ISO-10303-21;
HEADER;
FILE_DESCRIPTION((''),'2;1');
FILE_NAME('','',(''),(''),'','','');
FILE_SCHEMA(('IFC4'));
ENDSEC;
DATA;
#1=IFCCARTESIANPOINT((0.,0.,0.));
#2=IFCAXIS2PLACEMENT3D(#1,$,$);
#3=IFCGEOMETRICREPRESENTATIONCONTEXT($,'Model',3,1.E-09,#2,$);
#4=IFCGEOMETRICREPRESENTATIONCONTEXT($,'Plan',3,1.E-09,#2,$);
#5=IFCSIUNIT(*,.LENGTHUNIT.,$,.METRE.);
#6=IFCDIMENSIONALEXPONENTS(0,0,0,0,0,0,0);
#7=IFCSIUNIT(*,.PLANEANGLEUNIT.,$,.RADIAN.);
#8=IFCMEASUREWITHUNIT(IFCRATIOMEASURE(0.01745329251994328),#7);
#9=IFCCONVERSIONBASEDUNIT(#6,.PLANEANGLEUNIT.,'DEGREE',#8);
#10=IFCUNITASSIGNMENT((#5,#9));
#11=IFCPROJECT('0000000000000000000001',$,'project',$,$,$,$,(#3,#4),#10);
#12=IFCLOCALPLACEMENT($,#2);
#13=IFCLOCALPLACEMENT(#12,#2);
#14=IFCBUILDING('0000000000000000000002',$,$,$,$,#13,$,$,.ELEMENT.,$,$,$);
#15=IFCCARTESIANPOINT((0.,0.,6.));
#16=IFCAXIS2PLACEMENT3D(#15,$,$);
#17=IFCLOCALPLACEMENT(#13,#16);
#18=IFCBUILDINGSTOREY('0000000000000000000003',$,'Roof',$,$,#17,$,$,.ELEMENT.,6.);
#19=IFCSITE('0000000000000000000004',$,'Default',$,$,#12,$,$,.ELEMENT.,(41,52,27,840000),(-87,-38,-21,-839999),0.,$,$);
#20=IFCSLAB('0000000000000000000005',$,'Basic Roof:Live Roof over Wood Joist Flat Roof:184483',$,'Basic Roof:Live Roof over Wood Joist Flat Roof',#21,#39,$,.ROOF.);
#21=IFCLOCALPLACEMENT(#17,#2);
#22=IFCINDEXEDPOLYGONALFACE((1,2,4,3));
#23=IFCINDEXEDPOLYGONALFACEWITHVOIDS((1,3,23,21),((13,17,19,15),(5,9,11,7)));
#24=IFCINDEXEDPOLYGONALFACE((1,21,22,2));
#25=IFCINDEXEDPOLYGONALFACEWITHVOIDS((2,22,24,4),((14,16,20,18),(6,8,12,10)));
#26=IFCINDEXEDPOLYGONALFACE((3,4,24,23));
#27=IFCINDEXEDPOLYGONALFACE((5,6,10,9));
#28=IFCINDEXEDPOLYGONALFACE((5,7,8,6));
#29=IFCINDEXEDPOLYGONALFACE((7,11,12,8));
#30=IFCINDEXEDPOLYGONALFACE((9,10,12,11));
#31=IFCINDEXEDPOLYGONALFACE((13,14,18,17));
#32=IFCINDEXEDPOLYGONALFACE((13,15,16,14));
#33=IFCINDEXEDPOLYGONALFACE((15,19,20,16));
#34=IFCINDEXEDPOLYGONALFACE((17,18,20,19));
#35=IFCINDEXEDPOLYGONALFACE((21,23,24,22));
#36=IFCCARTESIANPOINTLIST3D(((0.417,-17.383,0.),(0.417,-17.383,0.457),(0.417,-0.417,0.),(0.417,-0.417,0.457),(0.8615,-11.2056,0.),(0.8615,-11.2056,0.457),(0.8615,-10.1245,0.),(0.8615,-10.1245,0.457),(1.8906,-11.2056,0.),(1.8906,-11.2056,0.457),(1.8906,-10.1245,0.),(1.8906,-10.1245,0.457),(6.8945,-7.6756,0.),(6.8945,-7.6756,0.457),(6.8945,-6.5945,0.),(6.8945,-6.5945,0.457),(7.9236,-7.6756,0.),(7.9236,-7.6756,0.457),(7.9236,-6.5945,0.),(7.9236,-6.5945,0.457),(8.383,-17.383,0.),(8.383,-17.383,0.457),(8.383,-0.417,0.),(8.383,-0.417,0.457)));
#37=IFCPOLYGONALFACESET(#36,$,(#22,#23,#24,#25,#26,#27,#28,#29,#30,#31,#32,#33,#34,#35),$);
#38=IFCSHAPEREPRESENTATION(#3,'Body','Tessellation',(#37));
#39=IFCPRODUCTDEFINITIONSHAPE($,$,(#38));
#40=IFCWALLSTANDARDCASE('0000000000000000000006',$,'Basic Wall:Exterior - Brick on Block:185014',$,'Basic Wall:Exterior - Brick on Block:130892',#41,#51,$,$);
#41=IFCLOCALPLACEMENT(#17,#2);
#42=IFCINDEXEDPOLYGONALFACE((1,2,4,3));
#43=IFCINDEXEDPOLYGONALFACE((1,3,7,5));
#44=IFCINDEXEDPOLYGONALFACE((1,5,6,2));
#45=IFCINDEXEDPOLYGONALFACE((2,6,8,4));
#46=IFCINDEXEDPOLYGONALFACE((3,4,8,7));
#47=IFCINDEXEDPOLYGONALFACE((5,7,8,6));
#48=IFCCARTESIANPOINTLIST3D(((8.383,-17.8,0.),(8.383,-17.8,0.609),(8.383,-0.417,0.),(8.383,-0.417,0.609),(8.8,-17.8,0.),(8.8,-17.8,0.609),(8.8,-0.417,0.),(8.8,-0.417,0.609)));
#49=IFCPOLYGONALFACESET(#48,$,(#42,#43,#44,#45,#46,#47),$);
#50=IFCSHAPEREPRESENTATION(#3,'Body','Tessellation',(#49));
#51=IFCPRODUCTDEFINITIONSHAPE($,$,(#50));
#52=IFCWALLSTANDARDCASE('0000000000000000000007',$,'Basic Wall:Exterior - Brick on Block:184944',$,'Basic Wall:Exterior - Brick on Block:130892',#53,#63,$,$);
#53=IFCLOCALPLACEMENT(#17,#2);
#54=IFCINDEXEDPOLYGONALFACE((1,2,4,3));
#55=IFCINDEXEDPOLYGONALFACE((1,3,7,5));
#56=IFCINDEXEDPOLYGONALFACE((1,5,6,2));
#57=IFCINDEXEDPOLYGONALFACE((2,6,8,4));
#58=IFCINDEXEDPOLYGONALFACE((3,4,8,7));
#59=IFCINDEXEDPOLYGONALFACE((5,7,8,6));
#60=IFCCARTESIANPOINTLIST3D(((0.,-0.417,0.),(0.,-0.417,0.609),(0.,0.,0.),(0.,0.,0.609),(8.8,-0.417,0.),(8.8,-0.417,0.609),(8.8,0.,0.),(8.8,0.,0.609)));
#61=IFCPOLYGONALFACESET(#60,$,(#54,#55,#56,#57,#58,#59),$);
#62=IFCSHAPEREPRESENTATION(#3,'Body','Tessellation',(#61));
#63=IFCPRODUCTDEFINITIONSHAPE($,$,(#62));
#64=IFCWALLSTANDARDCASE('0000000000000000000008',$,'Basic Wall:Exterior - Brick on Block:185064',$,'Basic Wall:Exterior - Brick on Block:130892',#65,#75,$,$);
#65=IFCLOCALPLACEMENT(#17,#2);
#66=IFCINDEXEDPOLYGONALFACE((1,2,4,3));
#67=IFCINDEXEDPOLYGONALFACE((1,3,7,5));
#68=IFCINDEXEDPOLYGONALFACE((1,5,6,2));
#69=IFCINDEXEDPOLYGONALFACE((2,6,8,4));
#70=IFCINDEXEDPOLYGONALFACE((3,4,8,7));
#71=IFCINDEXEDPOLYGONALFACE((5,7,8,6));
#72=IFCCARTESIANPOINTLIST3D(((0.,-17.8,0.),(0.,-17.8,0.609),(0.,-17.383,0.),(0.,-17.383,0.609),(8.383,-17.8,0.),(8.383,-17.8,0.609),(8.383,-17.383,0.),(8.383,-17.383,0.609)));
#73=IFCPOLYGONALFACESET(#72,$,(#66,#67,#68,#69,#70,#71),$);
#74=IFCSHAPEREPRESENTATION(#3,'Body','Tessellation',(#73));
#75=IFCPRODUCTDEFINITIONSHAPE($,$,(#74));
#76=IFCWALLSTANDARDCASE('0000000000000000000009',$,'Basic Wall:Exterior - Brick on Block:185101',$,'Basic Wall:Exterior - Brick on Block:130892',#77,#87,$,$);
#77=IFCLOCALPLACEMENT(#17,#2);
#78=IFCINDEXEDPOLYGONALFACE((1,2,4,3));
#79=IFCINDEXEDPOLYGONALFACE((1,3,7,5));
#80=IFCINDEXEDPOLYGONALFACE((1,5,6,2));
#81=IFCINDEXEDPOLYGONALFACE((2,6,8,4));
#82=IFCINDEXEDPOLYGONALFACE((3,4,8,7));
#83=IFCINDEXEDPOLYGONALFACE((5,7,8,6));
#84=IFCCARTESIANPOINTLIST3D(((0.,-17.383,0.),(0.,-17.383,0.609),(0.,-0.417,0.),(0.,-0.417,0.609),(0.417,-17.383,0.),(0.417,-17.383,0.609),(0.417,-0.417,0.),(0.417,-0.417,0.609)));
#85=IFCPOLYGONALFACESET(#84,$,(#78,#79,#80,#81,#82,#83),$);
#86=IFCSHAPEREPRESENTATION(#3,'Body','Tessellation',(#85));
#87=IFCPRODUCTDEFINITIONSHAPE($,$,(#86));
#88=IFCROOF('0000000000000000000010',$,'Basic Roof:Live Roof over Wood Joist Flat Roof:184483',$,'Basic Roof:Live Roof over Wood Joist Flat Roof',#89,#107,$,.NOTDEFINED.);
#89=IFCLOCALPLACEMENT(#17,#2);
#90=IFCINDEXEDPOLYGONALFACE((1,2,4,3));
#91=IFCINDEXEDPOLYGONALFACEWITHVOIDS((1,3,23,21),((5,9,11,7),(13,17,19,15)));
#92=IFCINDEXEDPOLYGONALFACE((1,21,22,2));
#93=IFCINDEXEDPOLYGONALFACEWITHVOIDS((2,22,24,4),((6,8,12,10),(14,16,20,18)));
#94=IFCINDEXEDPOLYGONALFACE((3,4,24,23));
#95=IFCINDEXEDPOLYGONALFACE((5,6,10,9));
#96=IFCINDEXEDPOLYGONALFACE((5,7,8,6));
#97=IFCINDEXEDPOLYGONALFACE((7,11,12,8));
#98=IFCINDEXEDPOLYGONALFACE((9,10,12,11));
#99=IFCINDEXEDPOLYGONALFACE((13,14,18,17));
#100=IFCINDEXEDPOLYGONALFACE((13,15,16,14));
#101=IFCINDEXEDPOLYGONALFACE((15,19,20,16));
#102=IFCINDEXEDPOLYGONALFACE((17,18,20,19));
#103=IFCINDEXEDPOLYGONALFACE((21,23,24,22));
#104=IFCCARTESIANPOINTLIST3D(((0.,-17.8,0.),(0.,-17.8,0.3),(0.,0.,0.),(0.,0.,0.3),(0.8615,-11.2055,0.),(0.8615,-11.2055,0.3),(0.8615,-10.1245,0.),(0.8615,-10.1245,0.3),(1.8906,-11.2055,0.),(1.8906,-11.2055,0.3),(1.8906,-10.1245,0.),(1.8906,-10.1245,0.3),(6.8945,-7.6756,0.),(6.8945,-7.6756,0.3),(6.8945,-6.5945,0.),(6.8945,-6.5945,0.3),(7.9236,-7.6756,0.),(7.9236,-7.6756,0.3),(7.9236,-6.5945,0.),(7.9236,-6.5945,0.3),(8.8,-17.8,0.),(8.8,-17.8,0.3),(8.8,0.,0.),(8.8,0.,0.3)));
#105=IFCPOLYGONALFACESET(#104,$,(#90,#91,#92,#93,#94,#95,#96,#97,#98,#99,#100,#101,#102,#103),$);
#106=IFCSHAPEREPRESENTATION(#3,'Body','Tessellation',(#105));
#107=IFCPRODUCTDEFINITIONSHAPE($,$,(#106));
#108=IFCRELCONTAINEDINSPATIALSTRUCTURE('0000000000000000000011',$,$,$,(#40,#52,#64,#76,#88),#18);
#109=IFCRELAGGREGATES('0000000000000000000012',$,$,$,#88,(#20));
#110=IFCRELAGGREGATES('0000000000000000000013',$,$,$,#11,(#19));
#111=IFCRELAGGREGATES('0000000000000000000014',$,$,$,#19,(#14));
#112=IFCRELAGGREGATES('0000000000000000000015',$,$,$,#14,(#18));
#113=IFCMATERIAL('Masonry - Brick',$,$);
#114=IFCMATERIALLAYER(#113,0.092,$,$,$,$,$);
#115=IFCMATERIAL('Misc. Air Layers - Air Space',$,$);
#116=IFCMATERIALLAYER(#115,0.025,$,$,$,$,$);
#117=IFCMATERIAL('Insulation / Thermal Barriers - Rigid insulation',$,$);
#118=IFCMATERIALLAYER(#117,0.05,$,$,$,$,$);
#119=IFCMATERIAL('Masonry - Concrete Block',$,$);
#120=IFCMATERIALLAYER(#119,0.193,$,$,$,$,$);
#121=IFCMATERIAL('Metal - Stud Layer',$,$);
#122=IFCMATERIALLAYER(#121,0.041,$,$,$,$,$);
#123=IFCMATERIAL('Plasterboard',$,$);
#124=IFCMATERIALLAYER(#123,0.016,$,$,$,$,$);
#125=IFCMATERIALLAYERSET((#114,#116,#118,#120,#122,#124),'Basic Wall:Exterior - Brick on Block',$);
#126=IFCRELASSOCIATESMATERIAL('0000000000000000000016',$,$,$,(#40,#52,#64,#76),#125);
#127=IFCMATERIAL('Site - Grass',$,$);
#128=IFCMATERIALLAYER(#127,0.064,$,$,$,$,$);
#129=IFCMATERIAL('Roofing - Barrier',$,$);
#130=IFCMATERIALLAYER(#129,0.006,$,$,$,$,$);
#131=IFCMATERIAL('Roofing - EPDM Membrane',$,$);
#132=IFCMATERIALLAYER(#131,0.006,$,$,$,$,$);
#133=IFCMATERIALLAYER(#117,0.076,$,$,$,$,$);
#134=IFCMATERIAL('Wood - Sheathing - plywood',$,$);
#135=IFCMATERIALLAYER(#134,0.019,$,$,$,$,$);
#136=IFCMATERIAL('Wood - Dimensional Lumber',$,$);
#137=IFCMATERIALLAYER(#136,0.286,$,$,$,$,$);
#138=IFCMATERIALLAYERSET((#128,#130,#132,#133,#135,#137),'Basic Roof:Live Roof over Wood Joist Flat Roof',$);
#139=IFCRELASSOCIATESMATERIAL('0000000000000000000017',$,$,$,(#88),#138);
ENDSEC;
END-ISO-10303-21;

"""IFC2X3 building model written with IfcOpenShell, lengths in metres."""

from ifc_helpers import new_model, entity, si_unit, converted_unit, frame, frame_2d, origin, origin_2d_with_axis, place, context, project, spatial, polyline, rectangle, outline, extrude, material, layer, layer_set, layer_usage, element, aggregate, save


model = new_model("IFC2X3")

# Units and contexts
model_context = context("Model", 3, precision=1e-09, world=origin())
plan_context = context("Plan", 3, precision=1e-09, world=origin())
ifc_project = project(units=[si_unit("LENGTHUNIT", "METRE"), converted_unit("PLANEANGLEUNIT", "DEGREE", entity("IfcRatioMeasure", 0.01745329251994328), si_unit("PLANEANGLEUNIT", "RADIAN"), dimensions=[0, 0, 0, 0, 0, 0, 0])], contexts=[model_context, plan_context])

# Slab, openings
site_placement = place(None, origin())
building_placement = place(site_placement, origin())
storey_placement = place(building_placement, frame((0.0, 0.0, 6.0)))
roof_placement = place(storey_placement, origin())
slab_placement = place(roof_placement, frame((0.417, -17.383, 0.0)))
slab = element("IfcSlab", 1, at=slab_placement, Name="Basic Roof:Live Roof over Wood Joist Flat Roof:184483", ObjectType="Basic Roof:Live Roof over Wood Joist Flat Roof", PredefinedType="ROOF", context=model_context, shape_type="SweptSolid", body=[
    extrude(rectangle(XDim=7.966, YDim=16.966, at=origin_2d_with_axis()), frame((3.983, 8.483, 0.0)), (0.0, 0.0, 1.0), 0.457),
])
opening_1_placement = place(roof_placement, frame((1.376, -10.665, 0.0)))
element("IfcOpeningElement", 2, at=opening_1_placement, cuts=slab, ObjectType="Opening", context=model_context, shape_type="SweptSolid", body=[
    extrude(rectangle(XDim=1.0291, YDim=1.0811, at=origin_2d_with_axis()), frame((0.0, 0.0, 0.0), z_axis=(0.0, 0.0, 1.0), x_axis=(-1.0, 0.0, 0.0)), (0.0, 0.0, 1.0), 0.457),
])
opening_2_placement = place(roof_placement, frame((7.409, -7.135, 0.0)))
element("IfcOpeningElement", 3, at=opening_2_placement, cuts=slab, ObjectType="Opening", context=model_context, shape_type="SweptSolid", body=[
    extrude(rectangle(XDim=1.0291, YDim=1.0811, at=origin_2d_with_axis()), frame((0.0, 0.0, 0.0), z_axis=(0.0, 0.0, 1.0), x_axis=(-1.0, 0.0, 0.0)), (0.0, 0.0, 1.0), 0.457),
])

# Site, building, storey
site = spatial("IfcSite", under=ifc_project, at=site_placement, Name="Default", CompositionType="ELEMENT", RefLatitude=(41, 52, 27, 840000), RefLongitude=(-87, -38, -21, -839999), RefElevation=0.0)
building = spatial("IfcBuilding", under=site, at=building_placement, CompositionType="ELEMENT")
storey = spatial("IfcBuildingStorey", under=building, at=storey_placement, Name="Roof", CompositionType="ELEMENT", Elevation=6.0)

# Walls
ifc_material_1 = material(Name="Masonry - Brick")
ifc_layer_1 = layer(ifc_material_1, 0.092)
ifc_material_2 = material(Name="Misc. Air Layers - Air Space")
ifc_layer_2 = layer(ifc_material_2, 0.025)
ifc_material_3 = material(Name="Insulation / Thermal Barriers - Rigid insulation")
ifc_layer_3 = layer(ifc_material_3, 0.05)
ifc_material_4 = material(Name="Masonry - Concrete Block")
ifc_layer_4 = layer(ifc_material_4, 0.193)
ifc_material_5 = material(Name="Metal - Stud Layer")
ifc_layer_5 = layer(ifc_material_5, 0.041)
ifc_material_6 = material(Name="Plasterboard")
ifc_layer_6 = layer(ifc_material_6, 0.016)
ifc_layer_set_1 = layer_set([ifc_layer_1, ifc_layer_2, ifc_layer_3, ifc_layer_4, ifc_layer_5, ifc_layer_6], Name="Basic Wall:Exterior - Brick on Block")
ifc_layer_usage_1 = layer_usage(ifc_layer_set_1, "AXIS2", "NEGATIVE", 0.2085)
wall_1_placement = place(storey_placement, frame((8.5915, -0.417, 0.0), z_axis=(0.0, 0.0, 1.0), x_axis=(0.0, -1.0, 0.0)))
element("IfcWallStandardCase", 4, at=wall_1_placement, inside=storey, material=ifc_layer_usage_1, Name="Basic Wall:Exterior - Brick on Block:185014", ObjectType="Basic Wall:Exterior - Brick on Block:130892", context=model_context, shape_type="SweptSolid", body=[
    extrude(rectangle(XDim=17.383, YDim=0.417, at=frame_2d((8.6915, 0.0), x_axis=(-1.0, 0.0))), origin(), (0.0, 0.0, 1.0), 0.609),
])
wall_2_placement = place(storey_placement, frame((0.0, -0.2085, 0.0)))
element("IfcWallStandardCase", 5, at=wall_2_placement, inside=storey, material=ifc_layer_usage_1, Name="Basic Wall:Exterior - Brick on Block:184944", ObjectType="Basic Wall:Exterior - Brick on Block:130892", context=model_context, shape_type="SweptSolid", body=[
    extrude(rectangle(XDim=8.8, YDim=0.417, at=frame_2d((4.4, 0.0), x_axis=(-1.0, 0.0))), origin(), (0.0, 0.0, 1.0), 0.609),
])
wall_3_placement = place(storey_placement, frame((8.383, -17.5915, 0.0), z_axis=(0.0, 0.0, 1.0), x_axis=(-1.0, 0.0, 0.0)))
element("IfcWallStandardCase", 6, at=wall_3_placement, inside=storey, material=ifc_layer_usage_1, Name="Basic Wall:Exterior - Brick on Block:185064", ObjectType="Basic Wall:Exterior - Brick on Block:130892", context=model_context, shape_type="SweptSolid", body=[
    extrude(rectangle(XDim=8.383, YDim=0.417, at=frame_2d((4.1915, 0.0), x_axis=(-1.0, 0.0))), origin(), (0.0, 0.0, 1.0), 0.609),
])
wall_4_placement = place(storey_placement, frame((0.2085, -17.383, 0.0), z_axis=(0.0, 0.0, 1.0), x_axis=(0.0, 1.0, 0.0)))
element("IfcWallStandardCase", 7, at=wall_4_placement, inside=storey, material=ifc_layer_usage_1, Name="Basic Wall:Exterior - Brick on Block:185101", ObjectType="Basic Wall:Exterior - Brick on Block:130892", context=model_context, shape_type="SweptSolid", body=[
    extrude(rectangle(XDim=16.966, YDim=0.417, at=frame_2d((8.483, 0.0), x_axis=(-1.0, 0.0))), origin(), (0.0, 0.0, 1.0), 0.609),
])

# Roof, openings
ifc_material_7 = material(Name="Site - Grass")
ifc_layer_7 = layer(ifc_material_7, 0.064)
ifc_material_8 = material(Name="Roofing - Barrier")
ifc_layer_8 = layer(ifc_material_8, 0.006)
ifc_material_9 = material(Name="Roofing - EPDM Membrane")
ifc_layer_9 = layer(ifc_material_9, 0.006)
ifc_layer_10 = layer(ifc_material_3, 0.076)
ifc_material_10 = material(Name="Wood - Sheathing - plywood")
ifc_layer_11 = layer(ifc_material_10, 0.019)
ifc_material_11 = material(Name="Wood - Dimensional Lumber")
ifc_layer_12 = layer(ifc_material_11, 0.286)
ifc_layer_set_2 = layer_set([ifc_layer_7, ifc_layer_8, ifc_layer_9, ifc_layer_10, ifc_layer_11, ifc_layer_12], Name="Basic Roof:Live Roof over Wood Joist Flat Roof")
ifc_layer_usage_2 = layer_usage(ifc_layer_set_2, "AXIS3", "NEGATIVE", 0.0)
roof = element("IfcRoof", 8, at=roof_placement, inside=storey, material=ifc_layer_usage_2, Name="Basic Roof:Live Roof over Wood Joist Flat Roof:184483", ObjectType="Basic Roof:Live Roof over Wood Joist Flat Roof", ShapeType="NOTDEFINED", context=model_context, shape_type="SweptSolid", body=[
    extrude(outline(polyline([(0.0, -17.8), (8.8, -17.8), (8.8, 0.0), (0.0, 0.0), (0.0, -17.8)])), origin(), (0.0, 0.0, 1.0), 0.3),
])
opening_3_placement = place(roof_placement, frame((0.417, -17.383, 0.0)))
element("IfcOpeningElement", 9, at=opening_3_placement, cuts=roof, ObjectType="Opening", context=model_context, shape_type="SweptSolid", body=[
    extrude(rectangle(XDim=1.0291, YDim=1.0811, at=origin_2d_with_axis()), frame((6.992, 10.248, -1.067), z_axis=(0.0, 0.0, 1.0), x_axis=(-1.0, 0.0, 0.0)), (0.0, 0.0, 1.0), 3.048),
])
opening_4_placement = place(roof_placement, frame((0.417, -17.383, 0.0)))
element("IfcOpeningElement", 10, at=opening_4_placement, cuts=roof, ObjectType="Opening", context=model_context, shape_type="SweptSolid", body=[
    extrude(rectangle(XDim=1.0291, YDim=1.0811, at=origin_2d_with_axis()), frame((0.959, 6.718, -1.067), z_axis=(0.0, 0.0, 1.0), x_axis=(-1.0, 0.0, 0.0)), (0.0, 0.0, 1.0), 3.048),
])
aggregate(roof, [slab])

save(model, "model.ifc")
